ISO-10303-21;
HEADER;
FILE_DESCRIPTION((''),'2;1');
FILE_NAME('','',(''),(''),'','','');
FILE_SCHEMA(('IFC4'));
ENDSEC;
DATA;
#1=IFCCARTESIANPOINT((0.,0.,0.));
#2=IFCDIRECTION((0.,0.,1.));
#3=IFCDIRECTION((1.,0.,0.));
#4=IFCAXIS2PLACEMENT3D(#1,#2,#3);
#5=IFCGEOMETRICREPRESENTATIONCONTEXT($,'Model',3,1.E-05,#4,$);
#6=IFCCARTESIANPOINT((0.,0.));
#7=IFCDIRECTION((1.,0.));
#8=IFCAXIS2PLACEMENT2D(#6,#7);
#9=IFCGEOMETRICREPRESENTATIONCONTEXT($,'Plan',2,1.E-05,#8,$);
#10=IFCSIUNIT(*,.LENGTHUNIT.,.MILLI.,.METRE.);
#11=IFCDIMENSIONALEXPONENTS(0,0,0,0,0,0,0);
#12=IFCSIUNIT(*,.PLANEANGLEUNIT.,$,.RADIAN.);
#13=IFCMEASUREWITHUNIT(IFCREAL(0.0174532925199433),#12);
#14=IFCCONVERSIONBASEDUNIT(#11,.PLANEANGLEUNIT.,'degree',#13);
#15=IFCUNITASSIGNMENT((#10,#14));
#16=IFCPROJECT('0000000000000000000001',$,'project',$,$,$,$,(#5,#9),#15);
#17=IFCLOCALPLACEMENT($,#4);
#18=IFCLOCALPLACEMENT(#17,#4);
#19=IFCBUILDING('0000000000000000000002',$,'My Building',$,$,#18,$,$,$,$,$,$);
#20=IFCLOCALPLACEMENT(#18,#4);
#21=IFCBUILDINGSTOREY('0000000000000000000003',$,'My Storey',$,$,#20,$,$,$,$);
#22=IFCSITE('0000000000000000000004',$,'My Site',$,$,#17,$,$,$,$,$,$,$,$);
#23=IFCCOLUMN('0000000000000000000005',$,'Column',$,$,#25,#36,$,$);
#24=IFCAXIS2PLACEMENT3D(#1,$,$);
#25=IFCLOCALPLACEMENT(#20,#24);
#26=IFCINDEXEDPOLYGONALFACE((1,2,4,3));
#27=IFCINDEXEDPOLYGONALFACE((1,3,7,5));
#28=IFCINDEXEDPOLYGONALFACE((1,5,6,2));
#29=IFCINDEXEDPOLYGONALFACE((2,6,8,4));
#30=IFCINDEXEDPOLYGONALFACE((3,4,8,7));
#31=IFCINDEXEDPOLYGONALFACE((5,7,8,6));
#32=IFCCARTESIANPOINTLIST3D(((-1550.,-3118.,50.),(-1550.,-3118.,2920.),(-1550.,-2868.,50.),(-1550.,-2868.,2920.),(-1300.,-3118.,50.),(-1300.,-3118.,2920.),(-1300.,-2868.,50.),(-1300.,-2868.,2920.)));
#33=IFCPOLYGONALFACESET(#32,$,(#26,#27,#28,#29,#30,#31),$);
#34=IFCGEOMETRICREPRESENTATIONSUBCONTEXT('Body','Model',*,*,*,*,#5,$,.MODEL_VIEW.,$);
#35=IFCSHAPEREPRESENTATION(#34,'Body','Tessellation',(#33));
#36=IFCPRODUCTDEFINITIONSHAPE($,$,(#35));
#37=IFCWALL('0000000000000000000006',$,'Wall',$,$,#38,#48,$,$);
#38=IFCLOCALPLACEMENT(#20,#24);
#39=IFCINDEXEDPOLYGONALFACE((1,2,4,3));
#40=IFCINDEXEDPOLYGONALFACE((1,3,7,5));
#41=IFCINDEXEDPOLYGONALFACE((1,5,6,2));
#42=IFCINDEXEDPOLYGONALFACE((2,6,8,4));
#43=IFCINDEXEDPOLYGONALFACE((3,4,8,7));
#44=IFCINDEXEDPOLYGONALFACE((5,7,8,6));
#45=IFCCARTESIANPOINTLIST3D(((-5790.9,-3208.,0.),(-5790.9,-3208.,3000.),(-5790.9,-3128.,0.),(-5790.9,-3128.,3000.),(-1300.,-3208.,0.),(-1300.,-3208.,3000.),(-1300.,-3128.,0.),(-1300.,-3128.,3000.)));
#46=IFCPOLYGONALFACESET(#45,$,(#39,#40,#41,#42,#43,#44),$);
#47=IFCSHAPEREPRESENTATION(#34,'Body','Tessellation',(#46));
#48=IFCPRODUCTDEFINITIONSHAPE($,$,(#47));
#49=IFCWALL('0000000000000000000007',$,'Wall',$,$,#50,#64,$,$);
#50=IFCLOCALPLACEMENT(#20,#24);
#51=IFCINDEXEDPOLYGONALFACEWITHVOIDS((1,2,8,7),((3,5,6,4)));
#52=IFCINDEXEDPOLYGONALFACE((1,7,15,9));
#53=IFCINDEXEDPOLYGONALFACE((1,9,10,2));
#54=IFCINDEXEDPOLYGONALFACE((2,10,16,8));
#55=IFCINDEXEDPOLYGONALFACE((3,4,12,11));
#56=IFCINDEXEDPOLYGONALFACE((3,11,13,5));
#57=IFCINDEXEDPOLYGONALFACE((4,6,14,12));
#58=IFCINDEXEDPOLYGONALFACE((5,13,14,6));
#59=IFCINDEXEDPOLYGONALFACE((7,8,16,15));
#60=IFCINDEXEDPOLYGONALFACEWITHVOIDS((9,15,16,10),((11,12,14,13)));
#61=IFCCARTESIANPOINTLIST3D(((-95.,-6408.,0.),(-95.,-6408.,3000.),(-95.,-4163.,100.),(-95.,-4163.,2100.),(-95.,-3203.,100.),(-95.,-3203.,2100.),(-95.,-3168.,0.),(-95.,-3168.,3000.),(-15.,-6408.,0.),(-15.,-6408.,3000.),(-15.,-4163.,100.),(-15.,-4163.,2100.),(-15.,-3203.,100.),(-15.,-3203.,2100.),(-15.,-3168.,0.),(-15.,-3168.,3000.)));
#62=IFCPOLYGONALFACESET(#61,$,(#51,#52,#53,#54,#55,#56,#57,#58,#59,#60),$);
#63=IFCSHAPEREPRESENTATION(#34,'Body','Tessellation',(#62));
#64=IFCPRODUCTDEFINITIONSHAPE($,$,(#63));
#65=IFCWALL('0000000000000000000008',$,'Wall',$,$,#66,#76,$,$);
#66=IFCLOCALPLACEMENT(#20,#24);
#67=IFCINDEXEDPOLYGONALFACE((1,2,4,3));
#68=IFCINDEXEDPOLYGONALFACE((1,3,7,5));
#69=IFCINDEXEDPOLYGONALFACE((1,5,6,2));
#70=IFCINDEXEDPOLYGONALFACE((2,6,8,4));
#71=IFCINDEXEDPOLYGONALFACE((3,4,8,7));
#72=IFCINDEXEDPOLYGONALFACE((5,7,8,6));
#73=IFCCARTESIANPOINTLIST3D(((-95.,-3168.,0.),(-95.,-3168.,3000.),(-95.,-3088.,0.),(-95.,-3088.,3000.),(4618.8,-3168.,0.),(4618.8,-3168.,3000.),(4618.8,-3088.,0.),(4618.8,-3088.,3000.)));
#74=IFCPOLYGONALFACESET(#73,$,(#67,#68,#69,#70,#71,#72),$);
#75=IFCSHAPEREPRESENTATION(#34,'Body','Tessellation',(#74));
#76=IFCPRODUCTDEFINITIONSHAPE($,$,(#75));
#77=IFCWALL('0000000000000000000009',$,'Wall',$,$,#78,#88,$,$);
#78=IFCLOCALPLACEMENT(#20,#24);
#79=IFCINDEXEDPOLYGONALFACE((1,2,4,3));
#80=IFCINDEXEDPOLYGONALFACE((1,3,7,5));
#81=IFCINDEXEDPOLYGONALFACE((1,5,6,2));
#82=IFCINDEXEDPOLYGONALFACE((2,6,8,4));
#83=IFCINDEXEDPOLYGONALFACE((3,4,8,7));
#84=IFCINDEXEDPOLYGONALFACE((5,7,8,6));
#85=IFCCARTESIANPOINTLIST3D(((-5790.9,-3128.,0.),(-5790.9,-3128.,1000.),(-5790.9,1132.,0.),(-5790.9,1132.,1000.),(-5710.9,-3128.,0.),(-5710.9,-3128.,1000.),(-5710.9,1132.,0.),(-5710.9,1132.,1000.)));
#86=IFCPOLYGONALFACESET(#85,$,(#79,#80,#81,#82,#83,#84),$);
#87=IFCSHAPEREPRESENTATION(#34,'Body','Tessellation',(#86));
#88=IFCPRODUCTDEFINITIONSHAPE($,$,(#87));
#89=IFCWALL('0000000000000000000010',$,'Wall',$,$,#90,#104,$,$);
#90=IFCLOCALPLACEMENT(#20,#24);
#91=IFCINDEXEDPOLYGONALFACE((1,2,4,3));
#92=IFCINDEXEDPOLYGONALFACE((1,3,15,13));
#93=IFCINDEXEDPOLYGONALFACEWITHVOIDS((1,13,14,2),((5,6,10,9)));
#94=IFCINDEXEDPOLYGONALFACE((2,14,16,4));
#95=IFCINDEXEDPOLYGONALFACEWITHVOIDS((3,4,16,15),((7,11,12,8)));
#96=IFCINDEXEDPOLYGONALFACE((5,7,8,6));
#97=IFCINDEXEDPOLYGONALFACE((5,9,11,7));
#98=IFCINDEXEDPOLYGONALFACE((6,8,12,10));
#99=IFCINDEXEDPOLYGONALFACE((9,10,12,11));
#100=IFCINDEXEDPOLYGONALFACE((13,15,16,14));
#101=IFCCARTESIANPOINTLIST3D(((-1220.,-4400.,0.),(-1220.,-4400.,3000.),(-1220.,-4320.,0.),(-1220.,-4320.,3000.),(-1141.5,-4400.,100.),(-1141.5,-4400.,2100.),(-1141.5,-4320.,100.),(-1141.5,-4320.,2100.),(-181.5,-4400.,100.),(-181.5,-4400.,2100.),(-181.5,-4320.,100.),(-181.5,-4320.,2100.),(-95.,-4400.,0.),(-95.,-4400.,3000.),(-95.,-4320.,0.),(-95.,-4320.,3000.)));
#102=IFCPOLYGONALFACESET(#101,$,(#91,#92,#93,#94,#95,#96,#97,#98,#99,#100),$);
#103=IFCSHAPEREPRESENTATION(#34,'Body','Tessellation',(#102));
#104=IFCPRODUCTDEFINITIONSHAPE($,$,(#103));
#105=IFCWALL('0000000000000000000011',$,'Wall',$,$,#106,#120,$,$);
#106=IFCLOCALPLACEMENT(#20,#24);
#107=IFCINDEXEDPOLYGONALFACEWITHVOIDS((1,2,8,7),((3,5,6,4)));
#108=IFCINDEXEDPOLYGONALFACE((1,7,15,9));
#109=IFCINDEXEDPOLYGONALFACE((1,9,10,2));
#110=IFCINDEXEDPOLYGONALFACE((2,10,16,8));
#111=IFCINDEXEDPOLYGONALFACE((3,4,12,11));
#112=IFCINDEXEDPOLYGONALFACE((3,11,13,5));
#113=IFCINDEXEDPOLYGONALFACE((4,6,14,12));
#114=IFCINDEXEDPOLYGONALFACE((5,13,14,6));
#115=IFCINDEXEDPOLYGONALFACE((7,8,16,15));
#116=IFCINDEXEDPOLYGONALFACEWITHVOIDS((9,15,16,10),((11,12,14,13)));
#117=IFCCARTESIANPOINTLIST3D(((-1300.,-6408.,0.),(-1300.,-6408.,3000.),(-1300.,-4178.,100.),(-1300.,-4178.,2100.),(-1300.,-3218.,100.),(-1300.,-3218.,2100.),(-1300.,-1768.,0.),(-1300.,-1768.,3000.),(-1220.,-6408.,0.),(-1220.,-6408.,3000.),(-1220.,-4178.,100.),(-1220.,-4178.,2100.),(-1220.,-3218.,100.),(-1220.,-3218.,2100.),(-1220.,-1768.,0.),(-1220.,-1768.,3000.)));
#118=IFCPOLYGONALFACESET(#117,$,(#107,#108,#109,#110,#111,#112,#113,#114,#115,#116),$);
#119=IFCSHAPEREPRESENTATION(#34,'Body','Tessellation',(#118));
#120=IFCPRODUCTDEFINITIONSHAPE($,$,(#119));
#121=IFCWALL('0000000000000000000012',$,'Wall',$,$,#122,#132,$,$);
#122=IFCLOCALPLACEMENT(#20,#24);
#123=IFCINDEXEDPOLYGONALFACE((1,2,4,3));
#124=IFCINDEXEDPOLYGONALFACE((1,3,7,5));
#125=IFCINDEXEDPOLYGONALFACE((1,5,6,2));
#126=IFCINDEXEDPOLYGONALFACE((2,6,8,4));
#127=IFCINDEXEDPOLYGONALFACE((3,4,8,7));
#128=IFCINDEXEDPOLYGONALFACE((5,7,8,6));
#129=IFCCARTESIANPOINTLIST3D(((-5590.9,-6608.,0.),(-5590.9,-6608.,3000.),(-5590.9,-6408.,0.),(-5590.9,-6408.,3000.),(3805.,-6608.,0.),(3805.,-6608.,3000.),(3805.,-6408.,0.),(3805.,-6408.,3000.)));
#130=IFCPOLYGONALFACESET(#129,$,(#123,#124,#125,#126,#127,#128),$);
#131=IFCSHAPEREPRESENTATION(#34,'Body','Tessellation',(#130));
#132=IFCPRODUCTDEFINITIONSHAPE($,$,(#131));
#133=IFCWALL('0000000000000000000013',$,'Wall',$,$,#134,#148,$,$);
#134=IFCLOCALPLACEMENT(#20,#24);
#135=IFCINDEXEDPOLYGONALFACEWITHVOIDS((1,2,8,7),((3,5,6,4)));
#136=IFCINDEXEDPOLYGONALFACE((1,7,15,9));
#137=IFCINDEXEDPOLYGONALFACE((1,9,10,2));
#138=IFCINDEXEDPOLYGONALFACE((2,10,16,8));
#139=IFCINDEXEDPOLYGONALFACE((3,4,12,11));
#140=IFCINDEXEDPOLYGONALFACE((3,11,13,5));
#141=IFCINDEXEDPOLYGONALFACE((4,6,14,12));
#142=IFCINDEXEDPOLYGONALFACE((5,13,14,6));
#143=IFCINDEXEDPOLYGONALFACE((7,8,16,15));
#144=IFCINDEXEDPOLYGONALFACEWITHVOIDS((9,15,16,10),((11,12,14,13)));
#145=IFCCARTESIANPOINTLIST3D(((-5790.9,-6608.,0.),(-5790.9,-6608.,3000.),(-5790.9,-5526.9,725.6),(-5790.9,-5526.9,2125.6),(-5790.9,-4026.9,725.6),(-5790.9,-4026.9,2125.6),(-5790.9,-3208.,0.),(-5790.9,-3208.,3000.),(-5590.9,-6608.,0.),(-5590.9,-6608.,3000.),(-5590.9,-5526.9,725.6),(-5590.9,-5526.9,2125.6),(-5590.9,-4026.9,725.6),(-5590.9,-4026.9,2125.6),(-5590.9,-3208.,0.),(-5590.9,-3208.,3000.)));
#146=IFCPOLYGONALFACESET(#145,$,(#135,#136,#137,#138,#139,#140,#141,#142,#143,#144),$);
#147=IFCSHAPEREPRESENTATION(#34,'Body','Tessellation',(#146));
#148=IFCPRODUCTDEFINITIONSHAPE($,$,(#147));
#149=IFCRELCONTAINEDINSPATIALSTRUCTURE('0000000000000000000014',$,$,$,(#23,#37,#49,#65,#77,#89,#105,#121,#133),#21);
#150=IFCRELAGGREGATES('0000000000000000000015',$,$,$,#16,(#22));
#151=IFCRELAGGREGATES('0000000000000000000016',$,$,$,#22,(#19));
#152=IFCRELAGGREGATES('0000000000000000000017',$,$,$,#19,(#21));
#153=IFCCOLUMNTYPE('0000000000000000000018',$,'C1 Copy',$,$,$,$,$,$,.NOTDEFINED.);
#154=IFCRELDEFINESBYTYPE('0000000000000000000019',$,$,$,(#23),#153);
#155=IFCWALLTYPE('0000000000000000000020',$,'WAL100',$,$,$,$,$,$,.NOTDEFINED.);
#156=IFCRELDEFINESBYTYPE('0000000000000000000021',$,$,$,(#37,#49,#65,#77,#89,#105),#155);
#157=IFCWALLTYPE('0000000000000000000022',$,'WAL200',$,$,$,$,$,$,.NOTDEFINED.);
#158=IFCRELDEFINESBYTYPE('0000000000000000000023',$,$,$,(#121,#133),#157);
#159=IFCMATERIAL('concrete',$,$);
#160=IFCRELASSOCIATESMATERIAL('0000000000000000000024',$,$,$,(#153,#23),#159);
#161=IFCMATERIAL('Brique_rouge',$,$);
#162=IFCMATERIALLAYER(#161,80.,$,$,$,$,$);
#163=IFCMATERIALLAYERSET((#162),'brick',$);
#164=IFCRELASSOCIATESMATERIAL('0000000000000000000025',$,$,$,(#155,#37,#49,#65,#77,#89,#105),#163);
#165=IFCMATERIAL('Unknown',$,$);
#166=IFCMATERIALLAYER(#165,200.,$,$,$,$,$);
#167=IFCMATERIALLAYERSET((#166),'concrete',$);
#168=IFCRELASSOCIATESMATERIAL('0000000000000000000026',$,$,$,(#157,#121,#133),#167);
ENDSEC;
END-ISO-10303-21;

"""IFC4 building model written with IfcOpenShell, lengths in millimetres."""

from ifc_helpers import new_model, entity, si_unit, converted_unit, frame, origin_with_axes, origin_2d_with_axis, place, context, subcontext, project, spatial, line, indexed_curve, rectangle, outline, extrude, source, transform, mapped, material, layer, layer_set, layer_usage, material_profile, profile_set, profile_usage, type_object, element, save


model = new_model("IFC4")

# Units and contexts
model_context = context("Model", 3, precision=1e-05, world=origin_with_axes())
plan_context = context("Plan", 2, precision=1e-05, world=origin_2d_with_axis())
body_context_1 = subcontext(model_context, "Body", "Model", "MODEL_VIEW")
ifc_project = project(units=[si_unit("LENGTHUNIT", "METRE", prefix="MILLI"), converted_unit("PLANEANGLEUNIT", "degree", entity("IfcReal", 0.0174532925199433), si_unit("PLANEANGLEUNIT", "RADIAN"), dimensions=[0, 0, 0, 0, 0, 0, 0])], contexts=[model_context, plan_context])

# Site, building, storey
site_placement = place(None, origin_with_axes())
site = spatial("IfcSite", under=ifc_project, at=site_placement, Name="My Site")
building_placement = place(site_placement, origin_with_axes())
building = spatial("IfcBuilding", under=site, at=building_placement, Name="My Building")
storey_placement = place(building_placement, origin_with_axes())
storey = spatial("IfcBuildingStorey", under=building, at=storey_placement, Name="My Storey")

# Column
ifc_material_1 = material(Name="concrete")
ifc_material_profile = material_profile(ifc_material_1, rectangle(XDim=250.0, YDim=250.0))
ifc_profile_set = profile_set([ifc_material_profile], Name="concrete")
ifc_profile_usage = profile_usage(ifc_profile_set)
column_type = type_object("IfcColumnType", Name="C1 Copy", PredefinedType="NOTDEFINED", material=ifc_profile_set)
column_placement = place(storey_placement, frame((-1425.0, -2993.0, 50.0), z_axis=(0.0, 0.0, 1.0), x_axis=(1.0, 0.0, 0.0)))
element("IfcColumn", 1, at=column_placement, inside=storey, type_object=column_type, material=ifc_profile_usage, Name="Column", context=body_context_1, shape_type="SweptSolid", body=[
    extrude(rectangle(XDim=250.0, YDim=250.0), origin_with_axes(), (0.0, 0.0, 1.0), 2870.0),
])

# Wall
ifc_material_2 = material(Name="Brique_rouge")
ifc_layer_1 = layer(ifc_material_2, 80.0)
ifc_layer_set_1 = layer_set([ifc_layer_1], Name="brick")
ifc_layer_usage_1 = layer_usage(ifc_layer_set_1, "AXIS2", "POSITIVE", 0.0)
wall_type_1 = type_object("IfcWallType", Name="WAL100", PredefinedType="NOTDEFINED", material=ifc_layer_set_1)
wall_1_placement = place(storey_placement, frame((-1300.0, -3128.0, 0.0), z_axis=(0.0, 0.0, 1.0), x_axis=(-1.0, 0.000001, 0.0)))
element("IfcWall", 2, at=wall_1_placement, inside=storey, type_object=wall_type_1, material=ifc_layer_usage_1, Name="Wall", context=body_context_1, shape_type="SweptSolid", body=[
    extrude(outline(indexed_curve([(0.0, 0.0), (0.0, 80.0), (4490.9, 80.0), (4490.9, 0.0), (0.0, 0.0)], self_intersect=False)), origin_with_axes(), (0.0, 0.0, 1.0), 3000.0),
])

# Wall, opening
ifc_layer_usage_2 = layer_usage(ifc_layer_set_1, "AXIS2", "POSITIVE", 0.0)
wall_2_placement = place(storey_placement, frame((-95.0, -3168.0, 0.0), z_axis=(0.0, 0.0, 1.0), x_axis=(-0.000001, -1.0, 0.0)))
wall_2 = element("IfcWall", 3, at=wall_2_placement, inside=storey, type_object=wall_type_1, material=ifc_layer_usage_2, Name="Wall", context=body_context_1, shape_type="SweptSolid", body=[
    extrude(outline(indexed_curve([(0.0, 0.0), (0.0, 80.0), (3240.0, 80.0), (3240.0, 0.0), (0.0, 0.0)], self_intersect=False)), origin_with_axes(), (0.0, 0.0, 1.0), 3000.0),
])
shared_shape_1 = source(origin_with_axes(), body_context_1, "Body", "SweptSolid", [
    extrude(outline(indexed_curve([(0.0, 0.0), (960.0, 0.0), (960.0, 2000.0), (0.0, 2000.0)], segments=[line(1, 2, 3, 4, 1)])), frame((0.0, -100.0, 0.0), z_axis=(0.0, -1.0, 0.0), x_axis=(1.0, 0.0, 0.0)), (0.0, 0.0, -1.0), 280.0),
])
opening_1_placement = place(wall_2_placement, frame((35.0, -2.5, 100.0), z_axis=(0.0, 0.0, 1.0), x_axis=(1.0, 0.0, 0.0)))
element("IfcOpeningElement", 4, at=opening_1_placement, cuts=wall_2, PredefinedType="OPENING", context=body_context_1, shape_type="MappedRepresentation", body=[
    mapped(shared_shape_1, transform((0.0, 0.0, 0.0), x_axis=(1.0, 0.0, 0.0), y_axis=(0.0, 1.0, 0.0), z_axis=(0.0, 0.0, 1.0), scale=1.0)),
])

# Walls
ifc_layer_usage_3 = layer_usage(ifc_layer_set_1, "AXIS2", "POSITIVE", 0.0)
wall_3_placement = place(storey_placement, frame((-95.0, -3168.0, 0.0), z_axis=(0.0, 0.0, 1.0), x_axis=(1.0, -0.000001, 0.0)))
element("IfcWall", 5, at=wall_3_placement, inside=storey, type_object=wall_type_1, material=ifc_layer_usage_3, Name="Wall", context=body_context_1, shape_type="SweptSolid", body=[
    extrude(outline(indexed_curve([(0.0, 0.0), (0.0, 80.0), (4713.8, 80.0), (4713.8, 0.0), (0.0, 0.0)], self_intersect=False)), origin_with_axes(), (0.0, 0.0, 1.0), 3000.0),
])
ifc_layer_usage_4 = layer_usage(ifc_layer_set_1, "AXIS2", "POSITIVE", 0.0)
wall_4_placement = place(storey_placement, frame((-5710.9, -3128.0, 0.0), z_axis=(0.0, 0.0, 1.0), x_axis=(0.000002, 1.0, 0.0)))
element("IfcWall", 6, at=wall_4_placement, inside=storey, type_object=wall_type_1, material=ifc_layer_usage_4, Name="Wall", context=body_context_1, shape_type="SweptSolid", body=[
    extrude(outline(indexed_curve([(0.0, 0.0), (0.0, 80.0), (4260.0, 80.0), (4260.0, 0.0), (0.0, 0.0)], self_intersect=False)), origin_with_axes(), (0.0, 0.0, 1.0), 1000.0),
])

# Walls, openings
ifc_layer_usage_5 = layer_usage(ifc_layer_set_1, "AXIS2", "POSITIVE", 0.0)
wall_5_placement = place(storey_placement, frame((-1220.0, -4400.0, 0.0), z_axis=(0.0, 0.0, 1.0), x_axis=(1.0, -0.000001, 0.0)))
wall_5 = element("IfcWall", 7, at=wall_5_placement, inside=storey, type_object=wall_type_1, material=ifc_layer_usage_5, Name="Wall", context=body_context_1, shape_type="SweptSolid", body=[
    extrude(outline(indexed_curve([(0.0, 0.0), (0.0, 80.0), (1125.0, 80.0), (1125.0, 0.0), (0.0, 0.0)], self_intersect=False)), origin_with_axes(), (0.0, 0.0, 1.0), 3000.0),
])
shared_shape_2 = source(origin_with_axes(), body_context_1, "Body", "SweptSolid", [
    extrude(outline(indexed_curve([(0.0, 0.0), (960.0, 0.0), (960.0, 2000.0), (0.0, 2000.0)], segments=[line(1, 2, 3, 4, 1)])), frame((0.0, -100.0, 0.0), z_axis=(0.0, -1.0, 0.0), x_axis=(1.0, 0.0, 0.0)), (0.0, 0.0, -1.0), 280.0),
])
opening_2_placement = place(wall_5_placement, frame((78.5, -2.5, 100.0), z_axis=(0.0, 0.0, 1.0), x_axis=(1.0, 0.0, 0.0)))
element("IfcOpeningElement", 8, at=opening_2_placement, cuts=wall_5, PredefinedType="OPENING", context=body_context_1, shape_type="MappedRepresentation", body=[
    mapped(shared_shape_2, transform((0.0, 0.0, 0.0), x_axis=(1.0, 0.0, 0.0), y_axis=(0.0, 1.0, 0.0), z_axis=(0.0, 0.0, 1.0), scale=1.0)),
])
ifc_layer_usage_6 = layer_usage(ifc_layer_set_1, "AXIS2", "POSITIVE", 0.0)
wall_6_placement = place(storey_placement, frame((-1300.0, -1768.0, 0.0), z_axis=(0.0, 0.0, 1.0), x_axis=(-0.000001, -1.0, 0.0)))
wall_6 = element("IfcWall", 9, at=wall_6_placement, inside=storey, type_object=wall_type_1, material=ifc_layer_usage_6, Name="Wall", context=body_context_1, shape_type="SweptSolid", body=[
    extrude(outline(indexed_curve([(0.0, 0.0), (0.0, 80.0), (4640.0, 80.0), (4640.0, 0.0), (0.0, 0.0)], self_intersect=False)), origin_with_axes(), (0.0, 0.0, 1.0), 3000.0),
])
opening_3_placement = place(wall_6_placement, frame((1450.0, 0.0, 100.0), z_axis=(0.0, 0.0, 1.0), x_axis=(1.0, 0.0, 0.0)))
element("IfcOpeningElement", 10, at=opening_3_placement, cuts=wall_6, PredefinedType="OPENING", context=body_context_1, shape_type="MappedRepresentation", body=[
    mapped(shared_shape_2, transform((0.0, 0.0, 0.0), x_axis=(1.0, 0.0, 0.0), y_axis=(0.0, 1.0, 0.0), z_axis=(0.0, 0.0, 1.0), scale=1.0)),
])

# Wall
ifc_material_3 = material(Name="Unknown")
ifc_layer_2 = layer(ifc_material_3, 200.0)
ifc_layer_set_2 = layer_set([ifc_layer_2], Name="concrete")
ifc_layer_usage_7 = layer_usage(ifc_layer_set_2, "AXIS2", "POSITIVE", 0.0)
wall_type_2 = type_object("IfcWallType", Name="WAL200", PredefinedType="NOTDEFINED", material=ifc_layer_set_2)
wall_7_placement = place(storey_placement, frame((-5590.9, -6608.0, 0.0), z_axis=(0.0, 0.0, 1.0), x_axis=(1.0, -0.000001, 0.0)))
element("IfcWall", 11, at=wall_7_placement, inside=storey, type_object=wall_type_2, material=ifc_layer_usage_7, Name="Wall", context=body_context_1, shape_type="SweptSolid", body=[
    extrude(outline(indexed_curve([(0.0, 0.0), (0.0, 200.0), (9395.9, 200.0), (9395.9, 0.0), (0.0, 0.0)], self_intersect=False)), origin_with_axes(), (0.0, 0.0, 1.0), 3000.0),
])

# Wall, opening
ifc_layer_usage_8 = layer_usage(ifc_layer_set_2, "AXIS2", "POSITIVE", 0.0)
wall_8_placement = place(storey_placement, frame((-5590.9, -6608.0, 0.0), z_axis=(0.0, 0.0, 1.0), x_axis=(0.000002, 1.0, 0.0)))
wall_8 = element("IfcWall", 12, at=wall_8_placement, inside=storey, type_object=wall_type_2, material=ifc_layer_usage_8, Name="Wall", context=body_context_1, shape_type="SweptSolid", body=[
    extrude(outline(indexed_curve([(0.0, 0.0), (0.0, 200.0), (3400.0, 200.0), (3400.0, 0.0), (0.0, 0.0)], self_intersect=False)), origin_with_axes(), (0.0, 0.0, 1.0), 3000.0),
])
shared_shape_3 = source(origin_with_axes(), body_context_1, "Body", "SweptSolid", [
    extrude(outline(indexed_curve([(0.0, 0.0), (1500.0, 0.0), (1500.0, 1400.0), (0.0, 1400.0)], segments=[line(1, 2, 3, 4, 1)])), frame((0.0, -100.0, 0.0), z_axis=(0.0, -1.0, 0.0), x_axis=(1.0, 0.0, 0.0)), (0.0, 0.0, -1.0), 400.0),
])
opening_4_placement = place(wall_8_placement, frame((1081.1, 0.0, 725.6), z_axis=(0.0, 0.0, 1.0), x_axis=(1.0, 0.0, 0.0)))
element("IfcOpeningElement", 13, at=opening_4_placement, cuts=wall_8, PredefinedType="OPENING", context=body_context_1, shape_type="MappedRepresentation", body=[
    mapped(shared_shape_3, transform((0.0, 0.0, 0.0), x_axis=(1.0, 0.0, 0.0), y_axis=(0.0, 1.0, 0.0), z_axis=(0.0, 0.0, 1.0), scale=1.0)),
])

save(model, "model.ifc")
